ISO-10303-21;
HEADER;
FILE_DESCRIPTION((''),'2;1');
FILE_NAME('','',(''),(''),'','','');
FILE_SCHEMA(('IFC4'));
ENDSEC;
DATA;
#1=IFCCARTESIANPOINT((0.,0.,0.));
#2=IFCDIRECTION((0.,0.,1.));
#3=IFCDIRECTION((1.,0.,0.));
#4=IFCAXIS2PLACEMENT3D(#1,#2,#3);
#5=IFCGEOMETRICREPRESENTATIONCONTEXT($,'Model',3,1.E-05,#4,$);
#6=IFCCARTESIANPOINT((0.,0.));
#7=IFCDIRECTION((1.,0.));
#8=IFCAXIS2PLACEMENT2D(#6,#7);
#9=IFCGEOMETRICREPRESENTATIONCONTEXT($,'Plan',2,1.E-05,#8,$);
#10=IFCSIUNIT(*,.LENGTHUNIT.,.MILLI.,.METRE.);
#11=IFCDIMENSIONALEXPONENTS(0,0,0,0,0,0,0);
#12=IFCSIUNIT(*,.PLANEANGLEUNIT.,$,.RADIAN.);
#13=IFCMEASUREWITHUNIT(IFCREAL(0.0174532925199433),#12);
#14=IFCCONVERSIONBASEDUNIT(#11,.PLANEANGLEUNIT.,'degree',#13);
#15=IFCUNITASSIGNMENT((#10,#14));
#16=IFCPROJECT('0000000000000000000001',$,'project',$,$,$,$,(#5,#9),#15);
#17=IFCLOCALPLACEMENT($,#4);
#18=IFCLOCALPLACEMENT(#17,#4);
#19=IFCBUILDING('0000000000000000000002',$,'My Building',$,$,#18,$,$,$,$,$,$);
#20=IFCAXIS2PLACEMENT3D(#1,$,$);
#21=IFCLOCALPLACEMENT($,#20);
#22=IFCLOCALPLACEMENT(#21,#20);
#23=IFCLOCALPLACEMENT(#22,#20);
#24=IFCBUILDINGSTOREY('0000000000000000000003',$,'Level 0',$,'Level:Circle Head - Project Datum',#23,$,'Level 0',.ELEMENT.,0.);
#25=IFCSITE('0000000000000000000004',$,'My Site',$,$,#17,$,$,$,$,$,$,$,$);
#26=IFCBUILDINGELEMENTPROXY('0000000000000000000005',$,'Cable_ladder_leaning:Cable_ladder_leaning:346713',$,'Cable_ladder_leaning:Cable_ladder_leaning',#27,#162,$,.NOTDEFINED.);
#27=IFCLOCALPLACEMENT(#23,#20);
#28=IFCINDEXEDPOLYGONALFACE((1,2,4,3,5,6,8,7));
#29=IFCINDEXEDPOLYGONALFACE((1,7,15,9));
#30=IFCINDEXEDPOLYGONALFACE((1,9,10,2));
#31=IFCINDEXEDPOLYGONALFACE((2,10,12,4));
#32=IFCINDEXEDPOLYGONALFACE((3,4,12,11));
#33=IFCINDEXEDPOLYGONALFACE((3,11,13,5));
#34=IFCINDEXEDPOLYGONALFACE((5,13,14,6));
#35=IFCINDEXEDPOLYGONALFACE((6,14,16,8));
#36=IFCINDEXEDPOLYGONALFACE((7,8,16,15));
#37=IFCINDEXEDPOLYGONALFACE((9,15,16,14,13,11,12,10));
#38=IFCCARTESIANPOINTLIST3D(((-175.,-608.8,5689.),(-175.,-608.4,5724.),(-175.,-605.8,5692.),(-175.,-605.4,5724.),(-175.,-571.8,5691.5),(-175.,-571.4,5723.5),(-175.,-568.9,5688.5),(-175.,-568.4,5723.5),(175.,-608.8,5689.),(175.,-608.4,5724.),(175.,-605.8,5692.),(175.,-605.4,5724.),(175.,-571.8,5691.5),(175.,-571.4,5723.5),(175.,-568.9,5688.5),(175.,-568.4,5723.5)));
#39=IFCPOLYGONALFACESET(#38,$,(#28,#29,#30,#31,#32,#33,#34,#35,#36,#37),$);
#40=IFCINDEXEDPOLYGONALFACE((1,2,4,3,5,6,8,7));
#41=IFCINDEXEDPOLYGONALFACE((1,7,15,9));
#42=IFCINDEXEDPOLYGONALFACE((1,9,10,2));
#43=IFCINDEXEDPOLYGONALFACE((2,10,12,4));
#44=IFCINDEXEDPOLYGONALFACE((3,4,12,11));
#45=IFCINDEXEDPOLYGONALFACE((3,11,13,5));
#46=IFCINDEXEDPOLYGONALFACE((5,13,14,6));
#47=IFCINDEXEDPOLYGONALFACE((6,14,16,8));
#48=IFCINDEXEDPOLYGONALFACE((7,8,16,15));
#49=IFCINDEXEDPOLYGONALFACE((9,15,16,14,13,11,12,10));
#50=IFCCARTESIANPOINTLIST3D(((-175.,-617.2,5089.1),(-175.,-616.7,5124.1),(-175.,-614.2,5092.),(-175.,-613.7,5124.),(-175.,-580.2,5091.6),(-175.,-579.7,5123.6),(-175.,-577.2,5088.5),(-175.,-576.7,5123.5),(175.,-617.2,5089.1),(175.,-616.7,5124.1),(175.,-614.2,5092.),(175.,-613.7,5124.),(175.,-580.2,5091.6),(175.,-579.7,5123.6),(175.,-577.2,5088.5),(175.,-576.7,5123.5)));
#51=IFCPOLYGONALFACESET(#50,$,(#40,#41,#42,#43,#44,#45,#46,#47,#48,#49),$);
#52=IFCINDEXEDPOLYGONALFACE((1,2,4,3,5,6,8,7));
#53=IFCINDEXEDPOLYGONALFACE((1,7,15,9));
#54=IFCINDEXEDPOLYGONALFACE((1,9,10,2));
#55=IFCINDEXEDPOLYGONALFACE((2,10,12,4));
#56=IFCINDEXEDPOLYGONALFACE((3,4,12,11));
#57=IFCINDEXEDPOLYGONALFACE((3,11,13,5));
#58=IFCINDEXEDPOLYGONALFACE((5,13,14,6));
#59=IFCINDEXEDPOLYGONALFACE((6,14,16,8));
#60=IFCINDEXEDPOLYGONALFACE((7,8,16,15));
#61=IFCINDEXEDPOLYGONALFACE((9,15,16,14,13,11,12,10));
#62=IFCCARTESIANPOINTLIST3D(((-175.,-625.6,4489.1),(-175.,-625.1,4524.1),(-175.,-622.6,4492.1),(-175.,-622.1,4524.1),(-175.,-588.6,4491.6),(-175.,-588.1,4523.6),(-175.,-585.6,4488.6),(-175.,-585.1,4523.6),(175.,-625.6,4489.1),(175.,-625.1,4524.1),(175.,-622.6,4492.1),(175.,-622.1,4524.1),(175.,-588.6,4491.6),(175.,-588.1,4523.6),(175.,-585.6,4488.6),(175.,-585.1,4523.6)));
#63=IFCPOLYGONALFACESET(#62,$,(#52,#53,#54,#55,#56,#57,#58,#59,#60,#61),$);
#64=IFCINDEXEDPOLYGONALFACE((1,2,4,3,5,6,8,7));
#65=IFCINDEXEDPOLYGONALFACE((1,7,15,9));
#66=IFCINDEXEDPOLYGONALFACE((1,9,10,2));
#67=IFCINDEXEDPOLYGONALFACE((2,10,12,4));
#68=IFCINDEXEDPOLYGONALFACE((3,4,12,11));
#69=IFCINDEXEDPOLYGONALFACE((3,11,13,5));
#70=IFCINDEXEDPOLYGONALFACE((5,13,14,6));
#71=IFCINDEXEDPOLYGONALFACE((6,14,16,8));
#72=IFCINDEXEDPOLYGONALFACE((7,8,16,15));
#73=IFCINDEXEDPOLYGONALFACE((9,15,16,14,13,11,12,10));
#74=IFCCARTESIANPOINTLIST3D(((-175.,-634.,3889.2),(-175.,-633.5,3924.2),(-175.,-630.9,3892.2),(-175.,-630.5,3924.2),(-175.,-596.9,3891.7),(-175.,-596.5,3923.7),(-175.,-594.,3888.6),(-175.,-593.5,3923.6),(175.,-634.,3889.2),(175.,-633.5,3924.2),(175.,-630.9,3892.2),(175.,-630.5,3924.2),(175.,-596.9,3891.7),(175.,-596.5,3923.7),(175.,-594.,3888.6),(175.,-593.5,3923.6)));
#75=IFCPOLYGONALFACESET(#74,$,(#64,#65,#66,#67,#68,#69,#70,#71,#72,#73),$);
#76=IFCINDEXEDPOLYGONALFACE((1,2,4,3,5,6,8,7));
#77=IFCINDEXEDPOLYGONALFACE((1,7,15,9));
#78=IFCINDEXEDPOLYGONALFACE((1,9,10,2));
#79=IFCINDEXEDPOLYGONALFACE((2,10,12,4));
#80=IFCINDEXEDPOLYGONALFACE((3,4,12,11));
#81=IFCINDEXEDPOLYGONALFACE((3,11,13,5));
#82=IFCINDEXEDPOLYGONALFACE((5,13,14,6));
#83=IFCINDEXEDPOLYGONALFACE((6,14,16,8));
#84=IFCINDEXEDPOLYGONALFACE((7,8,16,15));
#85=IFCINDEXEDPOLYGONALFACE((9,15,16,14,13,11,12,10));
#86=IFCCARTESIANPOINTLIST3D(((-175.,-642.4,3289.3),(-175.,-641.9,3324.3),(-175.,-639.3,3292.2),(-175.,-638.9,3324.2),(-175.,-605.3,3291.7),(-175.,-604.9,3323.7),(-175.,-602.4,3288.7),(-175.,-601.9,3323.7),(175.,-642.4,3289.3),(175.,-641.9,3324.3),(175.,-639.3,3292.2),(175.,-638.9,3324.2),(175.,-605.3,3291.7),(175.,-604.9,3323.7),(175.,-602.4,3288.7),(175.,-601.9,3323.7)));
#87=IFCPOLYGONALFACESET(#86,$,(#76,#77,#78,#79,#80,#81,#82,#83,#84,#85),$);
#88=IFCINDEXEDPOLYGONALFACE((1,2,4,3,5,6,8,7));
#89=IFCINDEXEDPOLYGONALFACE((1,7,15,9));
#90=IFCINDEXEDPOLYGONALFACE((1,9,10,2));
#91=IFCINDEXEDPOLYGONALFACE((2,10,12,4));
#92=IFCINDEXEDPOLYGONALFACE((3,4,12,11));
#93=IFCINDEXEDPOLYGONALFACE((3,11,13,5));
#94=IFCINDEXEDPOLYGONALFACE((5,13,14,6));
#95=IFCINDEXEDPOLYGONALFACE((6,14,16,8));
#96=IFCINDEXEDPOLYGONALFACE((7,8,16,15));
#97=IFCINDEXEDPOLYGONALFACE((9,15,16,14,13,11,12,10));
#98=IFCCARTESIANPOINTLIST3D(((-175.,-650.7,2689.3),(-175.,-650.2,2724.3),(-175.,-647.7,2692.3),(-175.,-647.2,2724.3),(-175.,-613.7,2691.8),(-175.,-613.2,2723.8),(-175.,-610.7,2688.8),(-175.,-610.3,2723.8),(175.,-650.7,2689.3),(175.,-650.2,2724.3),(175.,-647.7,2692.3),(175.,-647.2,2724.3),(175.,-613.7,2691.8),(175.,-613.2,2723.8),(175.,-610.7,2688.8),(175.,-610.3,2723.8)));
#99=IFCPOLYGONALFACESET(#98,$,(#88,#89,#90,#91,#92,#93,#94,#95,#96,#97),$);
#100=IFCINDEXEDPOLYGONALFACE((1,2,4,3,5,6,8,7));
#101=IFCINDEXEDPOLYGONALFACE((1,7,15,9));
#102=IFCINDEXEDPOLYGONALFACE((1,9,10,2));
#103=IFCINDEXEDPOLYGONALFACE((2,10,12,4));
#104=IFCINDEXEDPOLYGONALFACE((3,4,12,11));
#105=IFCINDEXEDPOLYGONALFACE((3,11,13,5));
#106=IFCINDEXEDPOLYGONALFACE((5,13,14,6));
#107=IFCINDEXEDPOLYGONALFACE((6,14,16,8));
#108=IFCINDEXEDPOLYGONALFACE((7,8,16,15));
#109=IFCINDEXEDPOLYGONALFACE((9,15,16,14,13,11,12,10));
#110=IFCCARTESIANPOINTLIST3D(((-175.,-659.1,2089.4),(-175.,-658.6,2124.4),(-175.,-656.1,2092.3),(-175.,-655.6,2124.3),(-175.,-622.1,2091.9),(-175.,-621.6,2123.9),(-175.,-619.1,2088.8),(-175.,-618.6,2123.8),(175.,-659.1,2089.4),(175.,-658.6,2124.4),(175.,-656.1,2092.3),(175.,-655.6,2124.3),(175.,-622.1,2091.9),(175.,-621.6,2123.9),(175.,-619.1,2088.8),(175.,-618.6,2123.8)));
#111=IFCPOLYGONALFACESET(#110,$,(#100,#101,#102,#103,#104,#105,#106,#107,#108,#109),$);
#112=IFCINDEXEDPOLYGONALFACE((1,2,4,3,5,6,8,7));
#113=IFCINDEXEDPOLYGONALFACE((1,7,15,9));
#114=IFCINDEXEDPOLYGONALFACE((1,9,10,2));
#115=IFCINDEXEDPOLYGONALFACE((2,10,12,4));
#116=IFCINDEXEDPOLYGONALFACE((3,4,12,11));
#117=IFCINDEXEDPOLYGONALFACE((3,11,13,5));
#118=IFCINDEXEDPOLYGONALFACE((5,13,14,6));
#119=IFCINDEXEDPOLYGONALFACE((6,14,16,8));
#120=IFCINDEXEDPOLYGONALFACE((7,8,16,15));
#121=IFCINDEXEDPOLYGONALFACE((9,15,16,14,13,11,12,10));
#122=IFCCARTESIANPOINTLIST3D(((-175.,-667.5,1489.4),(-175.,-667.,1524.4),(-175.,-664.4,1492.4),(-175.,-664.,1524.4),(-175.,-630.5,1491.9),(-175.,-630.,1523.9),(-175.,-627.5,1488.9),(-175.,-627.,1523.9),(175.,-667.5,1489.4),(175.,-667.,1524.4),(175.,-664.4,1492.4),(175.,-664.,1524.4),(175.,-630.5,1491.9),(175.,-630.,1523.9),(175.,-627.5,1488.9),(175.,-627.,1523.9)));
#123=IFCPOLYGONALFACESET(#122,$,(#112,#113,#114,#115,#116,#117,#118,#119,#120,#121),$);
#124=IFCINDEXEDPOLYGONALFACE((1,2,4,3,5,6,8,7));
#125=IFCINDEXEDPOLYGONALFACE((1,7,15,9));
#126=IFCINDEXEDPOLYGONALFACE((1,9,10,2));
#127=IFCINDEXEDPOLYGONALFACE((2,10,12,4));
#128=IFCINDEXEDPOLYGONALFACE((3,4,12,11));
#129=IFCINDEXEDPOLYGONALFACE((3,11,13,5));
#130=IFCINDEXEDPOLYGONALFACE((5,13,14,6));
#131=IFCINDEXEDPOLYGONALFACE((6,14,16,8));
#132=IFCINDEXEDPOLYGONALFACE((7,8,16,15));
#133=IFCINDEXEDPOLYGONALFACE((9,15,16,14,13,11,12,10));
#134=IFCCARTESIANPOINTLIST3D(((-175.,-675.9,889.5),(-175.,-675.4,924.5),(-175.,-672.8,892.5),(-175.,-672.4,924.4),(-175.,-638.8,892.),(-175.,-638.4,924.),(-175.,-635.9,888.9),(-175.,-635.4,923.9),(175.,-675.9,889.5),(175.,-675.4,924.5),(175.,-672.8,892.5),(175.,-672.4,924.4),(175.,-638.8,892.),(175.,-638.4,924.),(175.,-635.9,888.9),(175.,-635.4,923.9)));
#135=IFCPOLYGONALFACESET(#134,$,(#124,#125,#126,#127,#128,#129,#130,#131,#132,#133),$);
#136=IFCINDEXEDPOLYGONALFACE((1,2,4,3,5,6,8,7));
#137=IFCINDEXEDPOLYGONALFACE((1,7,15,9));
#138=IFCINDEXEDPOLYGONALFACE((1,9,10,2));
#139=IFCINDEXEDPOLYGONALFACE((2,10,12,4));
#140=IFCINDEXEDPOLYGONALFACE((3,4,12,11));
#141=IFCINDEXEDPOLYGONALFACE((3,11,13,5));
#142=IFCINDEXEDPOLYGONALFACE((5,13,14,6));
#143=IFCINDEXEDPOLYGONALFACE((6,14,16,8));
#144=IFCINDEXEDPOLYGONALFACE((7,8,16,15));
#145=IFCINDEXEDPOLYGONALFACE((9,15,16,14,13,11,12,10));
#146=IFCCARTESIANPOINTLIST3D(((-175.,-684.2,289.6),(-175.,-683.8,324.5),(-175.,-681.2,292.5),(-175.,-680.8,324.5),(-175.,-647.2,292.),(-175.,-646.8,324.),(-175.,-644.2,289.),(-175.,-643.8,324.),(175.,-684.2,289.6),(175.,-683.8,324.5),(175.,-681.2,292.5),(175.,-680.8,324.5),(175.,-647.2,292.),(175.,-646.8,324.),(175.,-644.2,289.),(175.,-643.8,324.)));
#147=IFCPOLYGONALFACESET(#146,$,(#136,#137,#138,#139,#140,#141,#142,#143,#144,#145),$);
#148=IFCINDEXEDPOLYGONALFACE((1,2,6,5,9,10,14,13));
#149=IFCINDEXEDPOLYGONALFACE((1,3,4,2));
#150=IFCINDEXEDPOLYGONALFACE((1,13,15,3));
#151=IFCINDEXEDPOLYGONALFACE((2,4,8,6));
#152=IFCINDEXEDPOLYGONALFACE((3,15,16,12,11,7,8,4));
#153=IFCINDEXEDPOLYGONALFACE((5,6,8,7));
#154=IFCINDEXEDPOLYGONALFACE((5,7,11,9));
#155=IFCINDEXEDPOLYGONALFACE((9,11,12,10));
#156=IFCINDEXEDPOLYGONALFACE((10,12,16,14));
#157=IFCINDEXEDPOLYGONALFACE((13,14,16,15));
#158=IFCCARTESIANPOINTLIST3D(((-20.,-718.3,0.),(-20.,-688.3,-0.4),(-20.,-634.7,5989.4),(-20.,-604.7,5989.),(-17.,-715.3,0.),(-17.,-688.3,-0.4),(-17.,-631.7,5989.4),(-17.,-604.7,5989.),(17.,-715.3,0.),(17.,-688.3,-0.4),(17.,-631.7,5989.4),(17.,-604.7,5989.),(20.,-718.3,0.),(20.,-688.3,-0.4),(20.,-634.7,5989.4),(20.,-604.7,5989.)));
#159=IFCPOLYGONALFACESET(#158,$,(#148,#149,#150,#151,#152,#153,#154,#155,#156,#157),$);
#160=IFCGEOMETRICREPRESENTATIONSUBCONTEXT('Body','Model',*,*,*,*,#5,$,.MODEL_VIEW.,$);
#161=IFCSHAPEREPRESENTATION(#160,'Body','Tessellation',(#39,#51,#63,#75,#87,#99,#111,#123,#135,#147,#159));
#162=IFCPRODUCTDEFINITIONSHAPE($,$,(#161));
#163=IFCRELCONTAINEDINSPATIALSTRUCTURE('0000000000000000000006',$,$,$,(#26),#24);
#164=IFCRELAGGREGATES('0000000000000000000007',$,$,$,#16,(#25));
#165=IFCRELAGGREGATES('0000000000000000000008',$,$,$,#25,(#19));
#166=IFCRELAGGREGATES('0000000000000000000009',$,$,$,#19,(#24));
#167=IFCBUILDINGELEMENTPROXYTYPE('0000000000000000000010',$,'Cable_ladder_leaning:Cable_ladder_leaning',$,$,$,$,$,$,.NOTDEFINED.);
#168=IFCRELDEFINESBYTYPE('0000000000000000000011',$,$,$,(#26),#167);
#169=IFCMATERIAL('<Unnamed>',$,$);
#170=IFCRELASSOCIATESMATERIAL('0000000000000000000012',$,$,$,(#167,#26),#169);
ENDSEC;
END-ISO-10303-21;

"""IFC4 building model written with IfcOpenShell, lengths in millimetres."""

from ifc_helpers import new_model, entity, si_unit, converted_unit, frame, origin, origin_with_axes, origin_2d_with_axis, place, context, subcontext, project, spatial, indexed_curve, outline, extrude, source, transform, mapped, material, type_object, type_shapes, element, save


model = new_model("IFC4")

# Units and contexts
model_context = context("Model", 3, precision=1e-05, world=origin_with_axes())
plan_context = context("Plan", 2, precision=1e-05, world=origin_2d_with_axis())
body_context = subcontext(model_context, "Body", "Model", "MODEL_VIEW")
ifc_project = project(units=[si_unit("LENGTHUNIT", "METRE", prefix="MILLI"), converted_unit("PLANEANGLEUNIT", "degree", entity("IfcReal", 0.0174532925199433), si_unit("PLANEANGLEUNIT", "RADIAN"), dimensions=[0, 0, 0, 0, 0, 0, 0])], contexts=[model_context, plan_context])

# Site, building, storey
site_placement = place(None, origin_with_axes())
site = spatial("IfcSite", under=ifc_project, at=site_placement, Name="My Site")
building_placement = place(site_placement, origin_with_axes())
building = spatial("IfcBuilding", under=site, at=building_placement, Name="My Building")
placement_1 = place(None, origin())
placement_2 = place(placement_1, origin())
storey_placement = place(placement_2, origin())
storey = spatial("IfcBuildingStorey", under=building, at=storey_placement, Name="Level 0", ObjectType="Level:Circle Head - Project Datum", LongName="Level 0", CompositionType="ELEMENT", Elevation=0.0)

# Shared definitions
ifc_material_1 = material(Name="<Unnamed>")

# Building element proxy
building_element_proxy_type_1 = type_object("IfcBuildingElementProxyType", Name="Cable_ladder_leaning:Cable_ladder_leaning", PredefinedType="NOTDEFINED", material=ifc_material_1)
shared_shape_1 = source(origin(), body_context, "Body", "SweptSolid", [
    extrude(outline(indexed_curve([(-20.0, -18.2), (20.0, -18.2), (20.0, 16.8), (17.0, 16.8), (17.0, -15.2), (-17.0, -15.2), (-17.0, 16.8), (-20.0, 16.8), (-20.0, -18.2)], self_intersect=False)), frame((-175.0, 129.7, 5707.0), z_axis=(1.0, 0.0, 0.0), x_axis=(0.0, 0.999903, -0.013962)), (0.0, 0.0, 1.0), 350.0),
    extrude(outline(indexed_curve([(-20.0, -18.2), (20.0, -18.2), (20.0, 16.7), (17.0, 16.8), (17.0, -15.2), (-17.0, -15.3), (-17.0, 16.8), (-20.0, 16.7), (-20.0, -18.2)], self_intersect=False)), frame((-175.0, 121.3, 5107.1), z_axis=(1.0, 0.0, 0.0), x_axis=(0.0, 0.999903, -0.013962)), (0.0, 0.0, 1.0), 350.0),
    extrude(outline(indexed_curve([(-20.0, -18.2), (20.0, -18.2), (20.0, 16.8), (17.0, 16.8), (17.0, -15.2), (-17.0, -15.2), (-17.0, 16.8), (-20.0, 16.8), (-20.0, -18.2)], self_intersect=False)), frame((-175.0, 112.9, 4507.1), z_axis=(1.0, 0.0, 0.0), x_axis=(0.0, 0.999903, -0.013962)), (0.0, 0.0, 1.0), 350.0),
    extrude(outline(indexed_curve([(-20.0, -18.2), (20.0, -18.2), (20.0, 16.8), (17.0, 16.7), (17.0, -15.2), (-17.0, -15.3), (-17.0, 16.7), (-20.0, 16.8), (-20.0, -18.2)], self_intersect=False)), frame((-175.0, 104.6, 3907.2), z_axis=(1.0, 0.0, 0.0), x_axis=(0.0, 0.999903, -0.013962)), (0.0, 0.0, 1.0), 350.0),
    extrude(outline(indexed_curve([(-20.0, -18.2), (20.0, -18.2), (20.0, 16.8), (17.0, 16.7), (17.0, -15.2), (-17.0, -15.3), (-17.0, 16.8), (-20.0, 16.8), (-20.0, -18.2)], self_intersect=False)), frame((-175.0, 96.2, 3307.2), z_axis=(1.0, 0.0, 0.0), x_axis=(0.0, 0.999903, -0.013962)), (0.0, 0.0, 1.0), 350.0),
    extrude(outline(indexed_curve([(-20.0, -18.2), (20.0, -18.2), (20.0, 16.8), (17.0, 16.7), (17.0, -15.2), (-17.0, -15.3), (-17.0, 16.8), (-20.0, 16.8), (-20.0, -18.2)], self_intersect=False)), frame((-175.0, 87.8, 2707.3), z_axis=(1.0, 0.0, 0.0), x_axis=(0.0, 0.999903, -0.013962)), (0.0, 0.0, 1.0), 350.0),
    extrude(outline(indexed_curve([(-20.0, -18.2), (20.0, -18.2), (20.0, 16.7), (17.0, 16.7), (17.0, -15.2), (-17.0, -15.2), (-17.0, 16.8), (-20.0, 16.8), (-20.0, -18.2)], self_intersect=False)), frame((-175.0, 79.4, 2107.3), z_axis=(1.0, 0.0, 0.0), x_axis=(0.0, 0.999903, -0.013962)), (0.0, 0.0, 1.0), 350.0),
    extrude(outline(indexed_curve([(-20.0, -18.2), (20.0, -18.2), (20.0, 16.7), (17.0, 16.7), (17.0, -15.2), (-17.0, -15.2), (-17.0, 16.8), (-20.0, 16.8), (-20.0, -18.2)], self_intersect=False)), frame((-175.0, 71.1, 1507.4), z_axis=(1.0, 0.0, 0.0), x_axis=(0.0, 0.999903, -0.013962)), (0.0, 0.0, 1.0), 350.0),
    extrude(outline(indexed_curve([(-20.0, -18.2), (20.0, -18.2), (20.0, 16.7), (17.0, 16.7), (17.0, -15.3), (-17.0, -15.3), (-17.0, 16.7), (-20.0, 16.7), (-20.0, -18.2)], self_intersect=False)), frame((-175.0, 62.7, 907.5), z_axis=(1.0, 0.0, 0.0), x_axis=(0.0, 0.999903, -0.013962)), (0.0, 0.0, 1.0), 350.0),
    extrude(outline(indexed_curve([(-20.0, -18.2), (20.0, -18.2), (20.0, 16.7), (17.0, 16.7), (17.0, -15.3), (-17.0, -15.3), (-17.0, 16.7), (-20.0, 16.7), (-20.0, -18.2)], self_intersect=False)), frame((-175.0, 54.3, 307.5), z_axis=(1.0, 0.0, 0.0), x_axis=(0.0, 0.999903, -0.013962)), (0.0, 0.0, 1.0), 350.0),
    extrude(outline(indexed_curve([(-14.2, -20.0), (15.8, -20.0), (15.8, 20.0), (-14.2, 20.0), (-14.2, 17.0), (12.8, 17.0), (12.7, -17.0), (-14.2, -17.0), (-14.2, -20.0)], self_intersect=False)), frame((0.0, 15.7, -0.2), z_axis=(0.0, 0.013962, 0.999903), x_axis=(0.0, -0.999903, 0.013962)), (0.0, 0.0, 1.0), 5990.0),
])
type_shapes(building_element_proxy_type_1, [shared_shape_1])
proxy_1_placement = place(storey_placement, frame((0.0, -718.3, 0.0)))
element("IfcBuildingElementProxy", 1, at=proxy_1_placement, inside=storey, type_object=building_element_proxy_type_1, material=ifc_material_1, Name="Cable_ladder_leaning:Cable_ladder_leaning:346713", ObjectType="Cable_ladder_leaning:Cable_ladder_leaning", PredefinedType="NOTDEFINED", context=body_context, shape_type="MappedRepresentation", body=[
    mapped(shared_shape_1, transform((0.0, 0.0, 0.0), scale=1.0)),
])

save(model, "model.ifc")
